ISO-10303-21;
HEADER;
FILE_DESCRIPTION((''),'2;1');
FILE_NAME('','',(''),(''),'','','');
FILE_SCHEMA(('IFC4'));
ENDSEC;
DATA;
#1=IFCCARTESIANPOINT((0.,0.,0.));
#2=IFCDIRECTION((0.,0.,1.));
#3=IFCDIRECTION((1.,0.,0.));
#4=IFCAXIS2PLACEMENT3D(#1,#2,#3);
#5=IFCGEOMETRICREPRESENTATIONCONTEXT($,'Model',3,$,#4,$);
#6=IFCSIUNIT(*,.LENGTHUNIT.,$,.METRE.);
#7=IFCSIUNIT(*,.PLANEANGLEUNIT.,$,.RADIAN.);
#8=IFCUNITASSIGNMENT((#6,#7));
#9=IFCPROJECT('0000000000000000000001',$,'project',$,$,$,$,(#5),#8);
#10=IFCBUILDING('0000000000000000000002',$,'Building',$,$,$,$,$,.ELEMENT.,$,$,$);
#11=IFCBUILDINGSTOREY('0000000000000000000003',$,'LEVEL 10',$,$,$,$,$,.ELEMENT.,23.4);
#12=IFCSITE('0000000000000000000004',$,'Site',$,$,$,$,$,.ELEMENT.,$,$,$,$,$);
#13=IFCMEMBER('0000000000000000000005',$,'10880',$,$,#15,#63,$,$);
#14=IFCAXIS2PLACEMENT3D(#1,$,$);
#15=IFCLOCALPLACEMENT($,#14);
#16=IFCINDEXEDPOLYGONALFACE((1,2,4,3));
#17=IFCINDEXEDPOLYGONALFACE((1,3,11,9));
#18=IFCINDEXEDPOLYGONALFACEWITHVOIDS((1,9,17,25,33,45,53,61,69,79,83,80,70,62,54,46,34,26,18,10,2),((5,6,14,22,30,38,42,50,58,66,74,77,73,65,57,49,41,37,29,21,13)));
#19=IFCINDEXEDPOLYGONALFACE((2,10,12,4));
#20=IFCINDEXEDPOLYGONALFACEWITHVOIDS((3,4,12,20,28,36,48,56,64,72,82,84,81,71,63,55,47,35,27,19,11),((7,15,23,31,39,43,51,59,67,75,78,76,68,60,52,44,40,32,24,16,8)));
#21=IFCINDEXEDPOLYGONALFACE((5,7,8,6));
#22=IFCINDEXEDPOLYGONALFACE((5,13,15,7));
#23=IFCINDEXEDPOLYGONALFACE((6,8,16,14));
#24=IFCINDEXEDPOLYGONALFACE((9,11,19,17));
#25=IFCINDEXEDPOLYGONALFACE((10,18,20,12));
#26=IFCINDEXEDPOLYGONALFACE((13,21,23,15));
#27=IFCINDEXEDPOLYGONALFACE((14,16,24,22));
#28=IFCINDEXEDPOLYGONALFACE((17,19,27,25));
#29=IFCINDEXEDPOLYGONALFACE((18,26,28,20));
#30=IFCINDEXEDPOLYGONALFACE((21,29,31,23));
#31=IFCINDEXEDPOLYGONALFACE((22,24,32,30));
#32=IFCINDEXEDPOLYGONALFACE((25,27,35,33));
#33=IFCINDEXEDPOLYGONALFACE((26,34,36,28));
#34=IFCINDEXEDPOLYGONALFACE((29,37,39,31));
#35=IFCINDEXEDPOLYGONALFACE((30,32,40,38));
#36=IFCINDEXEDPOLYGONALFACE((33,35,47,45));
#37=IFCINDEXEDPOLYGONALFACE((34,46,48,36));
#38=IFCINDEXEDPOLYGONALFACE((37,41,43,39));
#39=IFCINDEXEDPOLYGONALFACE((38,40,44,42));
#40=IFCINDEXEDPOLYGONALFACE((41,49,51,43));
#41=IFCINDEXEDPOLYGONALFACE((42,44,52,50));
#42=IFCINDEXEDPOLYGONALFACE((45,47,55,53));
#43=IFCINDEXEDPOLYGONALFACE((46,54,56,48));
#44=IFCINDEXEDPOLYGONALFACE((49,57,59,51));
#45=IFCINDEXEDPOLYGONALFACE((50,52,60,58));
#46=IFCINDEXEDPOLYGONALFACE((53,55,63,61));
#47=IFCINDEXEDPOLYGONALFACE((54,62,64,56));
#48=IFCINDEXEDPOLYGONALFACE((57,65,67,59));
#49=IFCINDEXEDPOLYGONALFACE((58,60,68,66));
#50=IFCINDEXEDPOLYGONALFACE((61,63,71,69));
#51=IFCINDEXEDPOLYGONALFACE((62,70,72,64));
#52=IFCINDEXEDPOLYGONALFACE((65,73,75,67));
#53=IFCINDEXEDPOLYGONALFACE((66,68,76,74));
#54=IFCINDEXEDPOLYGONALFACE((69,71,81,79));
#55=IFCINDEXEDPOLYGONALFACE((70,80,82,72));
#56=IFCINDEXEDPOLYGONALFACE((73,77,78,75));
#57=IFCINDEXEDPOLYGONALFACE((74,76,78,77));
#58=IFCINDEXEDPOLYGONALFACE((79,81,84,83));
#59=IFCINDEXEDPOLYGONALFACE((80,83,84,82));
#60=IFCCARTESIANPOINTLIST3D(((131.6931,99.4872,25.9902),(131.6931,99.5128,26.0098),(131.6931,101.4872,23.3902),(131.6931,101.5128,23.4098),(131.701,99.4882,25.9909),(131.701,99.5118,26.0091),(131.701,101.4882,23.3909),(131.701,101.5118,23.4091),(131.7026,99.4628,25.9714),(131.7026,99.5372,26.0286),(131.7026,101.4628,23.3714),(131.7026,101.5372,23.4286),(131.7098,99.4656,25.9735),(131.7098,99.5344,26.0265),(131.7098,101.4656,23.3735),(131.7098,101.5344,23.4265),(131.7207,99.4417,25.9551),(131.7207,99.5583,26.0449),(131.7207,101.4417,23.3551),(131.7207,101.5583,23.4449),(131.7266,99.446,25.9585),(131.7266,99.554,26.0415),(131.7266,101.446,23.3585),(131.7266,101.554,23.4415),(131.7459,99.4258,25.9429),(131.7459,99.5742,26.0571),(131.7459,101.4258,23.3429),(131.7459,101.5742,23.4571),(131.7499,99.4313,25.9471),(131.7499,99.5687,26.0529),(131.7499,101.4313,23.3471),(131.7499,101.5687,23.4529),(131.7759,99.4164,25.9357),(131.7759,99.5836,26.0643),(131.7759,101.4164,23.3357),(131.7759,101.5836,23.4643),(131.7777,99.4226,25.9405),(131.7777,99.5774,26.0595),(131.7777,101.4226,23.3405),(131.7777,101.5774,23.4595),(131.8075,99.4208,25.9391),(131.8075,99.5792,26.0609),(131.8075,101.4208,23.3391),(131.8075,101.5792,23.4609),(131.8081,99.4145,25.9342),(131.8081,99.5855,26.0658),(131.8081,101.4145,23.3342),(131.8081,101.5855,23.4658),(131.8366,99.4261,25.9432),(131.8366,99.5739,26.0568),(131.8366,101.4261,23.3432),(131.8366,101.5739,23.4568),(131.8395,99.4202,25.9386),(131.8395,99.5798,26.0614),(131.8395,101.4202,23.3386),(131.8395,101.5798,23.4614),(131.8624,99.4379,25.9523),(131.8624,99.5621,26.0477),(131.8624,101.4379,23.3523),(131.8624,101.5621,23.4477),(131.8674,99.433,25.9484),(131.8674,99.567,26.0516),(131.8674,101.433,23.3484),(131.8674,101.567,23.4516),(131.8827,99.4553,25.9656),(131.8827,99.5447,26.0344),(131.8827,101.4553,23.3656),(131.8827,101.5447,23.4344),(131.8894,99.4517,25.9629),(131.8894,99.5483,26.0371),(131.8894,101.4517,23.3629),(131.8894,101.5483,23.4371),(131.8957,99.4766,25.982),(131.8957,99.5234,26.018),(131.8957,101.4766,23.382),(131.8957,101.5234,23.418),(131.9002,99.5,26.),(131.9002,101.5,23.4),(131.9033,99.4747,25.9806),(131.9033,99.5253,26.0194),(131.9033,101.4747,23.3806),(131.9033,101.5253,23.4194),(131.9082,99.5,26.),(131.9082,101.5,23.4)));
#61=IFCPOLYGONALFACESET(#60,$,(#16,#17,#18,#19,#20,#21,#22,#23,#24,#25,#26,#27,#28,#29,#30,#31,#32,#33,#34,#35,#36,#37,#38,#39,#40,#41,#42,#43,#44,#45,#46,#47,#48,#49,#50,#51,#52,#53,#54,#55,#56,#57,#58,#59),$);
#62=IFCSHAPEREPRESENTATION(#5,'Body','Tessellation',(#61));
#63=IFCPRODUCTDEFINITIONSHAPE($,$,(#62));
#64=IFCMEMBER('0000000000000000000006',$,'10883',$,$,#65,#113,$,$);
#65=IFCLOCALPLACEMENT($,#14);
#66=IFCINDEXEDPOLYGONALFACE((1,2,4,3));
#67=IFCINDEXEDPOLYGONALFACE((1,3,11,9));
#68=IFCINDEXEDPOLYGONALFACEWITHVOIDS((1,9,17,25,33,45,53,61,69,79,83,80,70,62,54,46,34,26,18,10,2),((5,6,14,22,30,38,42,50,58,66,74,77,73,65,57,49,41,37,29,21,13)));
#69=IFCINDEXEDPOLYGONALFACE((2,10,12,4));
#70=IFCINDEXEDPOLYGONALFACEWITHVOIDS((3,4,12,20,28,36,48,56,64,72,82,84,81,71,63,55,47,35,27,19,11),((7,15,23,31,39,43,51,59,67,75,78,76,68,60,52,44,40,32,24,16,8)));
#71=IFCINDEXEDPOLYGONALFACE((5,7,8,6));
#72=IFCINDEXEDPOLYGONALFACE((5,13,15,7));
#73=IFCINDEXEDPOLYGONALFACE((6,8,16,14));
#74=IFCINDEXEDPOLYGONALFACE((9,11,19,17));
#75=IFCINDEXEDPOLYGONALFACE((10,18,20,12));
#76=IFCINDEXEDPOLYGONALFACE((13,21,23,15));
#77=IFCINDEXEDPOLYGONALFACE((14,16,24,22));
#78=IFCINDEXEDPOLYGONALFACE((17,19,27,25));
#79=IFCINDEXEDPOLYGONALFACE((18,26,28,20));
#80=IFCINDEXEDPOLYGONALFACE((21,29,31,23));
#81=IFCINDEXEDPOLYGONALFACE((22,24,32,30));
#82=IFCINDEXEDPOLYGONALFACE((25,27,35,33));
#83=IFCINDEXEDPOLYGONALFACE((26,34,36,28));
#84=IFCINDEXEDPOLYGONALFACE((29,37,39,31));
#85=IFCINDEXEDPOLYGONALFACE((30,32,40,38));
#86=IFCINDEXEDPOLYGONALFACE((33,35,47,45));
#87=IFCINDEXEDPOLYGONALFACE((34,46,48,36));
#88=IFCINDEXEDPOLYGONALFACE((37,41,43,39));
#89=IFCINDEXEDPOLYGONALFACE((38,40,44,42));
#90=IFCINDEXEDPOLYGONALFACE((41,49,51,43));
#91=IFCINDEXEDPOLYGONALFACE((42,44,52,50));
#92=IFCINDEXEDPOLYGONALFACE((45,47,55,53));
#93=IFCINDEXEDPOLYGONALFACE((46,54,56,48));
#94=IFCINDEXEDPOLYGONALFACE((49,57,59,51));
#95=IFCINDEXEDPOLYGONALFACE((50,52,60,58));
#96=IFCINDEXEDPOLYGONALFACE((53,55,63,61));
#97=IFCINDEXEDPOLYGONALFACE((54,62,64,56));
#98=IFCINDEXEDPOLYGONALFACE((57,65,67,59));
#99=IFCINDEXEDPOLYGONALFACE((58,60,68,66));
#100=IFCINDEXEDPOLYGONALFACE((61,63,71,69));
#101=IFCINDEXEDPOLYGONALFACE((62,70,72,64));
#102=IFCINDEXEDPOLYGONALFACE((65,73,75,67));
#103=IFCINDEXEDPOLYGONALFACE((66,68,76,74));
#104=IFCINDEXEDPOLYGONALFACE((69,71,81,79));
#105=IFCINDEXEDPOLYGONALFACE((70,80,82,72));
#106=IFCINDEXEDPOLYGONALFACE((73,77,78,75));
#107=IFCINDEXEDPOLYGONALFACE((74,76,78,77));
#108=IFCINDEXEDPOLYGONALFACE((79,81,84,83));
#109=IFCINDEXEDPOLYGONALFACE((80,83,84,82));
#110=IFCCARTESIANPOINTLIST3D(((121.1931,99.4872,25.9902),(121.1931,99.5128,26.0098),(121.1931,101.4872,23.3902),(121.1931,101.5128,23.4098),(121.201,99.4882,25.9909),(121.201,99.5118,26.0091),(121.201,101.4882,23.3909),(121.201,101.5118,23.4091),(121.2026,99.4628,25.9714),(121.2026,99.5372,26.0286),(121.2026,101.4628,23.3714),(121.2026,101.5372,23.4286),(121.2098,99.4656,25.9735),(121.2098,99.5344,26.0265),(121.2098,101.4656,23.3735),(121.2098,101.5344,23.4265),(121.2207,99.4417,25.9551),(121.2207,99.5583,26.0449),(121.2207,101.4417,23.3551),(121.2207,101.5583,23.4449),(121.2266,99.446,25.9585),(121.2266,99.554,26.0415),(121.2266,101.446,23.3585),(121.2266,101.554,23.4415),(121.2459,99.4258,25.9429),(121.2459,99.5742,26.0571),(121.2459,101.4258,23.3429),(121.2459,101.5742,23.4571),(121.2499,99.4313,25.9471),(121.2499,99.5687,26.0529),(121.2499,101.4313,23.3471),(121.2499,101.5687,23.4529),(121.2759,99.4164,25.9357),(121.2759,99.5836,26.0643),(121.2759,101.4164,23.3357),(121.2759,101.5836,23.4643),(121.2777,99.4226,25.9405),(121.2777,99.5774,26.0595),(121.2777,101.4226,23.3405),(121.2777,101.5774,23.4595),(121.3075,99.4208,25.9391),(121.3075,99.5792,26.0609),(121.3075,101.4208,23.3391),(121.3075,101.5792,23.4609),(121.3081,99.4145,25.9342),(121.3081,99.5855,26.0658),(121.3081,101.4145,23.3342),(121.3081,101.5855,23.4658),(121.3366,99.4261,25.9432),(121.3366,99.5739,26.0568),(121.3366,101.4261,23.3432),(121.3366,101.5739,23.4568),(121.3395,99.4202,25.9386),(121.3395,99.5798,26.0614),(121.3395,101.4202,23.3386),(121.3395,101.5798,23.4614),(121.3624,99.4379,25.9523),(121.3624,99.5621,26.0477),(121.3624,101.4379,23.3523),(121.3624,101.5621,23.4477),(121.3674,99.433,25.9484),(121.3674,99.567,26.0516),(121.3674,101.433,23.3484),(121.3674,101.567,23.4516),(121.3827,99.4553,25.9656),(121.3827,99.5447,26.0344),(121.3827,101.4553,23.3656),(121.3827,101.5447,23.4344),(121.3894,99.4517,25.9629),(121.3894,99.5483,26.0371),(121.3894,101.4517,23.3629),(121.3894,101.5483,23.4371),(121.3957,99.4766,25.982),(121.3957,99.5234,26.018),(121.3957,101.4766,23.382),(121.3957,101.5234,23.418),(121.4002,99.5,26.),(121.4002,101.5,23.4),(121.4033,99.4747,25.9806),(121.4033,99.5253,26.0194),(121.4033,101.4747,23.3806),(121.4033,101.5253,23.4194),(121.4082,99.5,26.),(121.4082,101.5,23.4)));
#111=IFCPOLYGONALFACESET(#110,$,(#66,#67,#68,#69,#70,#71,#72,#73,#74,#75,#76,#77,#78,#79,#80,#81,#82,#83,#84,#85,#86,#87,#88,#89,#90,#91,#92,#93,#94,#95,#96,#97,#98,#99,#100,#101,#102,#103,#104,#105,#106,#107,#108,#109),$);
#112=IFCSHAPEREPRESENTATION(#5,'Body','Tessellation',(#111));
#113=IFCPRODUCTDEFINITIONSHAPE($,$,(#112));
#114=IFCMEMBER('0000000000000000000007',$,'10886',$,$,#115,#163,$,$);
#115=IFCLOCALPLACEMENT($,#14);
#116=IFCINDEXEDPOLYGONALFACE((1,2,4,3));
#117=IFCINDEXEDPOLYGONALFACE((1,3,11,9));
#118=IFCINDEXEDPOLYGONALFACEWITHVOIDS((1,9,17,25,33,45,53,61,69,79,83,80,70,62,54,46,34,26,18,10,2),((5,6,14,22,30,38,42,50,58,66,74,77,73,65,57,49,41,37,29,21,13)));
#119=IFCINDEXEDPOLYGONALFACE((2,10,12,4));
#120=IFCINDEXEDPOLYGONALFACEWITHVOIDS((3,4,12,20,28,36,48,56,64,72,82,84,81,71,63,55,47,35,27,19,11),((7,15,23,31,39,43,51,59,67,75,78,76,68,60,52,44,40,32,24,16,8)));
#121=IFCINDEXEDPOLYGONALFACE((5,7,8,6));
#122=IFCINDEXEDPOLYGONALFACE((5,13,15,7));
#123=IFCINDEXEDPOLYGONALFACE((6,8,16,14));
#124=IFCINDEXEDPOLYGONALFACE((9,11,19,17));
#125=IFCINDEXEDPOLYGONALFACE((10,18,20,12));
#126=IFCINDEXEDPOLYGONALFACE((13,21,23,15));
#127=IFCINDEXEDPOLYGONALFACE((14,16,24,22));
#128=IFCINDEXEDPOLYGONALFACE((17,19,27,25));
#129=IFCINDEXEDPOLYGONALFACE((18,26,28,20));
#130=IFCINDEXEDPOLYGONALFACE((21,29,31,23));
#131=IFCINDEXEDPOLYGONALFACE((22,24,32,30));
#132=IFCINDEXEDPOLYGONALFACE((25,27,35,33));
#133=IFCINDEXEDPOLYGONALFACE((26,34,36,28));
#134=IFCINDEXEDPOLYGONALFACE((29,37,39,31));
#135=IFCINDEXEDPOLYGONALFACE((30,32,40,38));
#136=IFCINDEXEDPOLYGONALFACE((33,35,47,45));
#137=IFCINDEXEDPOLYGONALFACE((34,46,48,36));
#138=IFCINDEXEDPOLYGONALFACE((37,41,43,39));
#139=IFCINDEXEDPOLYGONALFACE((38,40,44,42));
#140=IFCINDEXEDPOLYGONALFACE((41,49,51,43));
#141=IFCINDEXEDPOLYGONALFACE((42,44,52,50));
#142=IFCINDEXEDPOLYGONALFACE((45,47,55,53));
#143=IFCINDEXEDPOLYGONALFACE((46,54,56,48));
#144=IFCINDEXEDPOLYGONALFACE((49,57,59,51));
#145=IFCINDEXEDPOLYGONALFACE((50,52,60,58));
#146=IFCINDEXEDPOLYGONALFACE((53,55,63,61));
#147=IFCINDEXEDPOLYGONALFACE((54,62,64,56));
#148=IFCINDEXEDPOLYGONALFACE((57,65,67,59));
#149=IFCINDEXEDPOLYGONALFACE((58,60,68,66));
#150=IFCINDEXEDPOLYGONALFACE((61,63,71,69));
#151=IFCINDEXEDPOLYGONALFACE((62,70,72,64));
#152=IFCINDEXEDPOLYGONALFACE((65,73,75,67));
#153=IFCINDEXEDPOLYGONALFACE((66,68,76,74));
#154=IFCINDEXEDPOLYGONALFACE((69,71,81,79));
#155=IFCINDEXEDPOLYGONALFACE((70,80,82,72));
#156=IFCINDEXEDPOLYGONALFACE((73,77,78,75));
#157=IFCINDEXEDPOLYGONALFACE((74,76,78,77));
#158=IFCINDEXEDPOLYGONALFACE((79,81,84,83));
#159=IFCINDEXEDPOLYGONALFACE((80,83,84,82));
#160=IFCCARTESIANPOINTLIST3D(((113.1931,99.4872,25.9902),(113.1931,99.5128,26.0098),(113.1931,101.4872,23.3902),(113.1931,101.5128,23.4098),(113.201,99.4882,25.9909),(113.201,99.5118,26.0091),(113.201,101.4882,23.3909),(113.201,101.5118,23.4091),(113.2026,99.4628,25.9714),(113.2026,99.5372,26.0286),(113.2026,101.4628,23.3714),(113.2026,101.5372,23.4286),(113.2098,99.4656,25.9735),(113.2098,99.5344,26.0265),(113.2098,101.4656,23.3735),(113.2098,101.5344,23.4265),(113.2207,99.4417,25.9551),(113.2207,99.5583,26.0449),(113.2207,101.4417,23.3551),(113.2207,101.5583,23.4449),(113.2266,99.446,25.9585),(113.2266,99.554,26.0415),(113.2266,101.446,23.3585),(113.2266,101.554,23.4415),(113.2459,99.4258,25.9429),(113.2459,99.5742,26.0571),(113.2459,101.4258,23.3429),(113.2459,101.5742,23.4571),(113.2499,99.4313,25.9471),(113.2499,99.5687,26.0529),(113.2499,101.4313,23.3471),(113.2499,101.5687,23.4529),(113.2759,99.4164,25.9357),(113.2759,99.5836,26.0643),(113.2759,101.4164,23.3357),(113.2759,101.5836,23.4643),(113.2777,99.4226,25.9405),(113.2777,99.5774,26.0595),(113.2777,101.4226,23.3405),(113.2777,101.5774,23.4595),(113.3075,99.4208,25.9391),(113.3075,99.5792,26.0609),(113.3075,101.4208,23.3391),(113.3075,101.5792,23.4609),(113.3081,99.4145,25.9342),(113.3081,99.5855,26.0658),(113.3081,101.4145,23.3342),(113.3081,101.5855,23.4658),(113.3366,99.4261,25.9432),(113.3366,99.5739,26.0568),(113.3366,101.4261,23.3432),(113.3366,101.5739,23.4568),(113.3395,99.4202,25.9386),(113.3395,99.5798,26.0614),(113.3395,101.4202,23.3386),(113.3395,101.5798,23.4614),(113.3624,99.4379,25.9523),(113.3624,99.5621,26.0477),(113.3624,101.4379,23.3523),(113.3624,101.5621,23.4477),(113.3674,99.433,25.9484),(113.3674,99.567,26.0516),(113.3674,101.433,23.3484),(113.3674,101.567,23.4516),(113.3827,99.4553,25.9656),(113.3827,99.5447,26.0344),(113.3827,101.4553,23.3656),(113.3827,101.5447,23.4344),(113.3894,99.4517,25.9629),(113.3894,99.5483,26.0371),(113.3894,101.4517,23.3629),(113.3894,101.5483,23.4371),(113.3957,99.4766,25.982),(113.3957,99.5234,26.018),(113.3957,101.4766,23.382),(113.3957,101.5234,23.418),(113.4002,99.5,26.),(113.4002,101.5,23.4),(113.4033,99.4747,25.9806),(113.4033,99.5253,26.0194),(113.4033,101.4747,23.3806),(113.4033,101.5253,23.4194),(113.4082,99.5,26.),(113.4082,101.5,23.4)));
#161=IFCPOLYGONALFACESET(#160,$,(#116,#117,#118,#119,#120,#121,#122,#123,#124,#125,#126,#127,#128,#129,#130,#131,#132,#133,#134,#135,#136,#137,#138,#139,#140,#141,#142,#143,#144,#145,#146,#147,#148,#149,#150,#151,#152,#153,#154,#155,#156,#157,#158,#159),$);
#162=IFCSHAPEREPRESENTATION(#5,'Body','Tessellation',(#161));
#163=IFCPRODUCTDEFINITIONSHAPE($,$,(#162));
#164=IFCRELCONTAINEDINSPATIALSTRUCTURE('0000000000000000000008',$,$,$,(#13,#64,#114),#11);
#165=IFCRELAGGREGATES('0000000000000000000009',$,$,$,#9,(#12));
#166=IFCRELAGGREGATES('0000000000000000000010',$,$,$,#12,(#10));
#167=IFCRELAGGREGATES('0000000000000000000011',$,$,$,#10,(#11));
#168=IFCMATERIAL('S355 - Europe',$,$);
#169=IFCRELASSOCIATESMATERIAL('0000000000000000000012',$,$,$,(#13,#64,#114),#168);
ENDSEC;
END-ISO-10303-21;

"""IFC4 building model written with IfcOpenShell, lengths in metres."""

from ifc_helpers import new_model, si_unit, frame, origin_with_axes, origin_2d_with_axis, place, context, project, spatial, hollow_circle, extrude, material, material_profile, profile_set, profile_usage, element, save


model = new_model("IFC4")

# Units and contexts
model_context = context("Model", 3, world=origin_with_axes())
ifc_project = project(units=[si_unit("LENGTHUNIT", "METRE"), si_unit("PLANEANGLEUNIT", "RADIAN")], contexts=[model_context])

# Site, building, storey
site = spatial("IfcSite", under=ifc_project, Name="Site", CompositionType="ELEMENT")
building = spatial("IfcBuilding", under=site, Name="Building", CompositionType="ELEMENT")
storey = spatial("IfcBuildingStorey", under=building, Name="LEVEL 10", CompositionType="ELEMENT", Elevation=23.4)

# Shared definitions
ifc_material = material(Name="S355 - Europe")

# Members
ifc_material_profile_1 = material_profile(ifc_material, hollow_circle(Radius=0.1081, WallThickness=0.008, at=origin_2d_with_axis()))
ifc_profile_set_1 = profile_set([ifc_material_profile_1])
ifc_profile_usage_1 = profile_usage(ifc_profile_set_1, cardinal=10)
member_1_placement = place(None, frame((131.8, 101.5, 23.4), z_axis=(0.0, -0.609711, 0.792624), x_axis=(1.0, 0.0, 0.0)))
element("IfcMember", 1, at=member_1_placement, inside=storey, material=ifc_profile_usage_1, Name="10880", context=model_context, shape_type="SweptSolid", body=[
    extrude(hollow_circle(Radius=0.1081, WallThickness=0.008, at=origin_2d_with_axis()), origin_with_axes(), (0.0, 0.0, 1.0), 3.2802),
])
ifc_material_profile_2 = material_profile(ifc_material, hollow_circle(Radius=0.1081, WallThickness=0.008, at=origin_2d_with_axis()))
ifc_profile_set_2 = profile_set([ifc_material_profile_2])
ifc_profile_usage_2 = profile_usage(ifc_profile_set_2, cardinal=10)
member_2_placement = place(None, frame((121.3, 101.5, 23.4), z_axis=(0.0, -0.609711, 0.792624), x_axis=(1.0, 0.0, 0.0)))
element("IfcMember", 2, at=member_2_placement, inside=storey, material=ifc_profile_usage_2, Name="10883", context=model_context, shape_type="SweptSolid", body=[
    extrude(hollow_circle(Radius=0.1081, WallThickness=0.008, at=origin_2d_with_axis()), origin_with_axes(), (0.0, 0.0, 1.0), 3.2802),
])
ifc_material_profile_3 = material_profile(ifc_material, hollow_circle(Radius=0.1081, WallThickness=0.008, at=origin_2d_with_axis()))
ifc_profile_set_3 = profile_set([ifc_material_profile_3])
ifc_profile_usage_3 = profile_usage(ifc_profile_set_3, cardinal=10)
member_3_placement = place(None, frame((113.3, 101.5, 23.4), z_axis=(0.0, -0.609711, 0.792624), x_axis=(1.0, 0.0, 0.0)))
element("IfcMember", 3, at=member_3_placement, inside=storey, material=ifc_profile_usage_3, Name="10886", context=model_context, shape_type="SweptSolid", body=[
    extrude(hollow_circle(Radius=0.1081, WallThickness=0.008, at=origin_2d_with_axis()), origin_with_axes(), (0.0, 0.0, 1.0), 3.2802),
])

save(model, "model.ifc")
